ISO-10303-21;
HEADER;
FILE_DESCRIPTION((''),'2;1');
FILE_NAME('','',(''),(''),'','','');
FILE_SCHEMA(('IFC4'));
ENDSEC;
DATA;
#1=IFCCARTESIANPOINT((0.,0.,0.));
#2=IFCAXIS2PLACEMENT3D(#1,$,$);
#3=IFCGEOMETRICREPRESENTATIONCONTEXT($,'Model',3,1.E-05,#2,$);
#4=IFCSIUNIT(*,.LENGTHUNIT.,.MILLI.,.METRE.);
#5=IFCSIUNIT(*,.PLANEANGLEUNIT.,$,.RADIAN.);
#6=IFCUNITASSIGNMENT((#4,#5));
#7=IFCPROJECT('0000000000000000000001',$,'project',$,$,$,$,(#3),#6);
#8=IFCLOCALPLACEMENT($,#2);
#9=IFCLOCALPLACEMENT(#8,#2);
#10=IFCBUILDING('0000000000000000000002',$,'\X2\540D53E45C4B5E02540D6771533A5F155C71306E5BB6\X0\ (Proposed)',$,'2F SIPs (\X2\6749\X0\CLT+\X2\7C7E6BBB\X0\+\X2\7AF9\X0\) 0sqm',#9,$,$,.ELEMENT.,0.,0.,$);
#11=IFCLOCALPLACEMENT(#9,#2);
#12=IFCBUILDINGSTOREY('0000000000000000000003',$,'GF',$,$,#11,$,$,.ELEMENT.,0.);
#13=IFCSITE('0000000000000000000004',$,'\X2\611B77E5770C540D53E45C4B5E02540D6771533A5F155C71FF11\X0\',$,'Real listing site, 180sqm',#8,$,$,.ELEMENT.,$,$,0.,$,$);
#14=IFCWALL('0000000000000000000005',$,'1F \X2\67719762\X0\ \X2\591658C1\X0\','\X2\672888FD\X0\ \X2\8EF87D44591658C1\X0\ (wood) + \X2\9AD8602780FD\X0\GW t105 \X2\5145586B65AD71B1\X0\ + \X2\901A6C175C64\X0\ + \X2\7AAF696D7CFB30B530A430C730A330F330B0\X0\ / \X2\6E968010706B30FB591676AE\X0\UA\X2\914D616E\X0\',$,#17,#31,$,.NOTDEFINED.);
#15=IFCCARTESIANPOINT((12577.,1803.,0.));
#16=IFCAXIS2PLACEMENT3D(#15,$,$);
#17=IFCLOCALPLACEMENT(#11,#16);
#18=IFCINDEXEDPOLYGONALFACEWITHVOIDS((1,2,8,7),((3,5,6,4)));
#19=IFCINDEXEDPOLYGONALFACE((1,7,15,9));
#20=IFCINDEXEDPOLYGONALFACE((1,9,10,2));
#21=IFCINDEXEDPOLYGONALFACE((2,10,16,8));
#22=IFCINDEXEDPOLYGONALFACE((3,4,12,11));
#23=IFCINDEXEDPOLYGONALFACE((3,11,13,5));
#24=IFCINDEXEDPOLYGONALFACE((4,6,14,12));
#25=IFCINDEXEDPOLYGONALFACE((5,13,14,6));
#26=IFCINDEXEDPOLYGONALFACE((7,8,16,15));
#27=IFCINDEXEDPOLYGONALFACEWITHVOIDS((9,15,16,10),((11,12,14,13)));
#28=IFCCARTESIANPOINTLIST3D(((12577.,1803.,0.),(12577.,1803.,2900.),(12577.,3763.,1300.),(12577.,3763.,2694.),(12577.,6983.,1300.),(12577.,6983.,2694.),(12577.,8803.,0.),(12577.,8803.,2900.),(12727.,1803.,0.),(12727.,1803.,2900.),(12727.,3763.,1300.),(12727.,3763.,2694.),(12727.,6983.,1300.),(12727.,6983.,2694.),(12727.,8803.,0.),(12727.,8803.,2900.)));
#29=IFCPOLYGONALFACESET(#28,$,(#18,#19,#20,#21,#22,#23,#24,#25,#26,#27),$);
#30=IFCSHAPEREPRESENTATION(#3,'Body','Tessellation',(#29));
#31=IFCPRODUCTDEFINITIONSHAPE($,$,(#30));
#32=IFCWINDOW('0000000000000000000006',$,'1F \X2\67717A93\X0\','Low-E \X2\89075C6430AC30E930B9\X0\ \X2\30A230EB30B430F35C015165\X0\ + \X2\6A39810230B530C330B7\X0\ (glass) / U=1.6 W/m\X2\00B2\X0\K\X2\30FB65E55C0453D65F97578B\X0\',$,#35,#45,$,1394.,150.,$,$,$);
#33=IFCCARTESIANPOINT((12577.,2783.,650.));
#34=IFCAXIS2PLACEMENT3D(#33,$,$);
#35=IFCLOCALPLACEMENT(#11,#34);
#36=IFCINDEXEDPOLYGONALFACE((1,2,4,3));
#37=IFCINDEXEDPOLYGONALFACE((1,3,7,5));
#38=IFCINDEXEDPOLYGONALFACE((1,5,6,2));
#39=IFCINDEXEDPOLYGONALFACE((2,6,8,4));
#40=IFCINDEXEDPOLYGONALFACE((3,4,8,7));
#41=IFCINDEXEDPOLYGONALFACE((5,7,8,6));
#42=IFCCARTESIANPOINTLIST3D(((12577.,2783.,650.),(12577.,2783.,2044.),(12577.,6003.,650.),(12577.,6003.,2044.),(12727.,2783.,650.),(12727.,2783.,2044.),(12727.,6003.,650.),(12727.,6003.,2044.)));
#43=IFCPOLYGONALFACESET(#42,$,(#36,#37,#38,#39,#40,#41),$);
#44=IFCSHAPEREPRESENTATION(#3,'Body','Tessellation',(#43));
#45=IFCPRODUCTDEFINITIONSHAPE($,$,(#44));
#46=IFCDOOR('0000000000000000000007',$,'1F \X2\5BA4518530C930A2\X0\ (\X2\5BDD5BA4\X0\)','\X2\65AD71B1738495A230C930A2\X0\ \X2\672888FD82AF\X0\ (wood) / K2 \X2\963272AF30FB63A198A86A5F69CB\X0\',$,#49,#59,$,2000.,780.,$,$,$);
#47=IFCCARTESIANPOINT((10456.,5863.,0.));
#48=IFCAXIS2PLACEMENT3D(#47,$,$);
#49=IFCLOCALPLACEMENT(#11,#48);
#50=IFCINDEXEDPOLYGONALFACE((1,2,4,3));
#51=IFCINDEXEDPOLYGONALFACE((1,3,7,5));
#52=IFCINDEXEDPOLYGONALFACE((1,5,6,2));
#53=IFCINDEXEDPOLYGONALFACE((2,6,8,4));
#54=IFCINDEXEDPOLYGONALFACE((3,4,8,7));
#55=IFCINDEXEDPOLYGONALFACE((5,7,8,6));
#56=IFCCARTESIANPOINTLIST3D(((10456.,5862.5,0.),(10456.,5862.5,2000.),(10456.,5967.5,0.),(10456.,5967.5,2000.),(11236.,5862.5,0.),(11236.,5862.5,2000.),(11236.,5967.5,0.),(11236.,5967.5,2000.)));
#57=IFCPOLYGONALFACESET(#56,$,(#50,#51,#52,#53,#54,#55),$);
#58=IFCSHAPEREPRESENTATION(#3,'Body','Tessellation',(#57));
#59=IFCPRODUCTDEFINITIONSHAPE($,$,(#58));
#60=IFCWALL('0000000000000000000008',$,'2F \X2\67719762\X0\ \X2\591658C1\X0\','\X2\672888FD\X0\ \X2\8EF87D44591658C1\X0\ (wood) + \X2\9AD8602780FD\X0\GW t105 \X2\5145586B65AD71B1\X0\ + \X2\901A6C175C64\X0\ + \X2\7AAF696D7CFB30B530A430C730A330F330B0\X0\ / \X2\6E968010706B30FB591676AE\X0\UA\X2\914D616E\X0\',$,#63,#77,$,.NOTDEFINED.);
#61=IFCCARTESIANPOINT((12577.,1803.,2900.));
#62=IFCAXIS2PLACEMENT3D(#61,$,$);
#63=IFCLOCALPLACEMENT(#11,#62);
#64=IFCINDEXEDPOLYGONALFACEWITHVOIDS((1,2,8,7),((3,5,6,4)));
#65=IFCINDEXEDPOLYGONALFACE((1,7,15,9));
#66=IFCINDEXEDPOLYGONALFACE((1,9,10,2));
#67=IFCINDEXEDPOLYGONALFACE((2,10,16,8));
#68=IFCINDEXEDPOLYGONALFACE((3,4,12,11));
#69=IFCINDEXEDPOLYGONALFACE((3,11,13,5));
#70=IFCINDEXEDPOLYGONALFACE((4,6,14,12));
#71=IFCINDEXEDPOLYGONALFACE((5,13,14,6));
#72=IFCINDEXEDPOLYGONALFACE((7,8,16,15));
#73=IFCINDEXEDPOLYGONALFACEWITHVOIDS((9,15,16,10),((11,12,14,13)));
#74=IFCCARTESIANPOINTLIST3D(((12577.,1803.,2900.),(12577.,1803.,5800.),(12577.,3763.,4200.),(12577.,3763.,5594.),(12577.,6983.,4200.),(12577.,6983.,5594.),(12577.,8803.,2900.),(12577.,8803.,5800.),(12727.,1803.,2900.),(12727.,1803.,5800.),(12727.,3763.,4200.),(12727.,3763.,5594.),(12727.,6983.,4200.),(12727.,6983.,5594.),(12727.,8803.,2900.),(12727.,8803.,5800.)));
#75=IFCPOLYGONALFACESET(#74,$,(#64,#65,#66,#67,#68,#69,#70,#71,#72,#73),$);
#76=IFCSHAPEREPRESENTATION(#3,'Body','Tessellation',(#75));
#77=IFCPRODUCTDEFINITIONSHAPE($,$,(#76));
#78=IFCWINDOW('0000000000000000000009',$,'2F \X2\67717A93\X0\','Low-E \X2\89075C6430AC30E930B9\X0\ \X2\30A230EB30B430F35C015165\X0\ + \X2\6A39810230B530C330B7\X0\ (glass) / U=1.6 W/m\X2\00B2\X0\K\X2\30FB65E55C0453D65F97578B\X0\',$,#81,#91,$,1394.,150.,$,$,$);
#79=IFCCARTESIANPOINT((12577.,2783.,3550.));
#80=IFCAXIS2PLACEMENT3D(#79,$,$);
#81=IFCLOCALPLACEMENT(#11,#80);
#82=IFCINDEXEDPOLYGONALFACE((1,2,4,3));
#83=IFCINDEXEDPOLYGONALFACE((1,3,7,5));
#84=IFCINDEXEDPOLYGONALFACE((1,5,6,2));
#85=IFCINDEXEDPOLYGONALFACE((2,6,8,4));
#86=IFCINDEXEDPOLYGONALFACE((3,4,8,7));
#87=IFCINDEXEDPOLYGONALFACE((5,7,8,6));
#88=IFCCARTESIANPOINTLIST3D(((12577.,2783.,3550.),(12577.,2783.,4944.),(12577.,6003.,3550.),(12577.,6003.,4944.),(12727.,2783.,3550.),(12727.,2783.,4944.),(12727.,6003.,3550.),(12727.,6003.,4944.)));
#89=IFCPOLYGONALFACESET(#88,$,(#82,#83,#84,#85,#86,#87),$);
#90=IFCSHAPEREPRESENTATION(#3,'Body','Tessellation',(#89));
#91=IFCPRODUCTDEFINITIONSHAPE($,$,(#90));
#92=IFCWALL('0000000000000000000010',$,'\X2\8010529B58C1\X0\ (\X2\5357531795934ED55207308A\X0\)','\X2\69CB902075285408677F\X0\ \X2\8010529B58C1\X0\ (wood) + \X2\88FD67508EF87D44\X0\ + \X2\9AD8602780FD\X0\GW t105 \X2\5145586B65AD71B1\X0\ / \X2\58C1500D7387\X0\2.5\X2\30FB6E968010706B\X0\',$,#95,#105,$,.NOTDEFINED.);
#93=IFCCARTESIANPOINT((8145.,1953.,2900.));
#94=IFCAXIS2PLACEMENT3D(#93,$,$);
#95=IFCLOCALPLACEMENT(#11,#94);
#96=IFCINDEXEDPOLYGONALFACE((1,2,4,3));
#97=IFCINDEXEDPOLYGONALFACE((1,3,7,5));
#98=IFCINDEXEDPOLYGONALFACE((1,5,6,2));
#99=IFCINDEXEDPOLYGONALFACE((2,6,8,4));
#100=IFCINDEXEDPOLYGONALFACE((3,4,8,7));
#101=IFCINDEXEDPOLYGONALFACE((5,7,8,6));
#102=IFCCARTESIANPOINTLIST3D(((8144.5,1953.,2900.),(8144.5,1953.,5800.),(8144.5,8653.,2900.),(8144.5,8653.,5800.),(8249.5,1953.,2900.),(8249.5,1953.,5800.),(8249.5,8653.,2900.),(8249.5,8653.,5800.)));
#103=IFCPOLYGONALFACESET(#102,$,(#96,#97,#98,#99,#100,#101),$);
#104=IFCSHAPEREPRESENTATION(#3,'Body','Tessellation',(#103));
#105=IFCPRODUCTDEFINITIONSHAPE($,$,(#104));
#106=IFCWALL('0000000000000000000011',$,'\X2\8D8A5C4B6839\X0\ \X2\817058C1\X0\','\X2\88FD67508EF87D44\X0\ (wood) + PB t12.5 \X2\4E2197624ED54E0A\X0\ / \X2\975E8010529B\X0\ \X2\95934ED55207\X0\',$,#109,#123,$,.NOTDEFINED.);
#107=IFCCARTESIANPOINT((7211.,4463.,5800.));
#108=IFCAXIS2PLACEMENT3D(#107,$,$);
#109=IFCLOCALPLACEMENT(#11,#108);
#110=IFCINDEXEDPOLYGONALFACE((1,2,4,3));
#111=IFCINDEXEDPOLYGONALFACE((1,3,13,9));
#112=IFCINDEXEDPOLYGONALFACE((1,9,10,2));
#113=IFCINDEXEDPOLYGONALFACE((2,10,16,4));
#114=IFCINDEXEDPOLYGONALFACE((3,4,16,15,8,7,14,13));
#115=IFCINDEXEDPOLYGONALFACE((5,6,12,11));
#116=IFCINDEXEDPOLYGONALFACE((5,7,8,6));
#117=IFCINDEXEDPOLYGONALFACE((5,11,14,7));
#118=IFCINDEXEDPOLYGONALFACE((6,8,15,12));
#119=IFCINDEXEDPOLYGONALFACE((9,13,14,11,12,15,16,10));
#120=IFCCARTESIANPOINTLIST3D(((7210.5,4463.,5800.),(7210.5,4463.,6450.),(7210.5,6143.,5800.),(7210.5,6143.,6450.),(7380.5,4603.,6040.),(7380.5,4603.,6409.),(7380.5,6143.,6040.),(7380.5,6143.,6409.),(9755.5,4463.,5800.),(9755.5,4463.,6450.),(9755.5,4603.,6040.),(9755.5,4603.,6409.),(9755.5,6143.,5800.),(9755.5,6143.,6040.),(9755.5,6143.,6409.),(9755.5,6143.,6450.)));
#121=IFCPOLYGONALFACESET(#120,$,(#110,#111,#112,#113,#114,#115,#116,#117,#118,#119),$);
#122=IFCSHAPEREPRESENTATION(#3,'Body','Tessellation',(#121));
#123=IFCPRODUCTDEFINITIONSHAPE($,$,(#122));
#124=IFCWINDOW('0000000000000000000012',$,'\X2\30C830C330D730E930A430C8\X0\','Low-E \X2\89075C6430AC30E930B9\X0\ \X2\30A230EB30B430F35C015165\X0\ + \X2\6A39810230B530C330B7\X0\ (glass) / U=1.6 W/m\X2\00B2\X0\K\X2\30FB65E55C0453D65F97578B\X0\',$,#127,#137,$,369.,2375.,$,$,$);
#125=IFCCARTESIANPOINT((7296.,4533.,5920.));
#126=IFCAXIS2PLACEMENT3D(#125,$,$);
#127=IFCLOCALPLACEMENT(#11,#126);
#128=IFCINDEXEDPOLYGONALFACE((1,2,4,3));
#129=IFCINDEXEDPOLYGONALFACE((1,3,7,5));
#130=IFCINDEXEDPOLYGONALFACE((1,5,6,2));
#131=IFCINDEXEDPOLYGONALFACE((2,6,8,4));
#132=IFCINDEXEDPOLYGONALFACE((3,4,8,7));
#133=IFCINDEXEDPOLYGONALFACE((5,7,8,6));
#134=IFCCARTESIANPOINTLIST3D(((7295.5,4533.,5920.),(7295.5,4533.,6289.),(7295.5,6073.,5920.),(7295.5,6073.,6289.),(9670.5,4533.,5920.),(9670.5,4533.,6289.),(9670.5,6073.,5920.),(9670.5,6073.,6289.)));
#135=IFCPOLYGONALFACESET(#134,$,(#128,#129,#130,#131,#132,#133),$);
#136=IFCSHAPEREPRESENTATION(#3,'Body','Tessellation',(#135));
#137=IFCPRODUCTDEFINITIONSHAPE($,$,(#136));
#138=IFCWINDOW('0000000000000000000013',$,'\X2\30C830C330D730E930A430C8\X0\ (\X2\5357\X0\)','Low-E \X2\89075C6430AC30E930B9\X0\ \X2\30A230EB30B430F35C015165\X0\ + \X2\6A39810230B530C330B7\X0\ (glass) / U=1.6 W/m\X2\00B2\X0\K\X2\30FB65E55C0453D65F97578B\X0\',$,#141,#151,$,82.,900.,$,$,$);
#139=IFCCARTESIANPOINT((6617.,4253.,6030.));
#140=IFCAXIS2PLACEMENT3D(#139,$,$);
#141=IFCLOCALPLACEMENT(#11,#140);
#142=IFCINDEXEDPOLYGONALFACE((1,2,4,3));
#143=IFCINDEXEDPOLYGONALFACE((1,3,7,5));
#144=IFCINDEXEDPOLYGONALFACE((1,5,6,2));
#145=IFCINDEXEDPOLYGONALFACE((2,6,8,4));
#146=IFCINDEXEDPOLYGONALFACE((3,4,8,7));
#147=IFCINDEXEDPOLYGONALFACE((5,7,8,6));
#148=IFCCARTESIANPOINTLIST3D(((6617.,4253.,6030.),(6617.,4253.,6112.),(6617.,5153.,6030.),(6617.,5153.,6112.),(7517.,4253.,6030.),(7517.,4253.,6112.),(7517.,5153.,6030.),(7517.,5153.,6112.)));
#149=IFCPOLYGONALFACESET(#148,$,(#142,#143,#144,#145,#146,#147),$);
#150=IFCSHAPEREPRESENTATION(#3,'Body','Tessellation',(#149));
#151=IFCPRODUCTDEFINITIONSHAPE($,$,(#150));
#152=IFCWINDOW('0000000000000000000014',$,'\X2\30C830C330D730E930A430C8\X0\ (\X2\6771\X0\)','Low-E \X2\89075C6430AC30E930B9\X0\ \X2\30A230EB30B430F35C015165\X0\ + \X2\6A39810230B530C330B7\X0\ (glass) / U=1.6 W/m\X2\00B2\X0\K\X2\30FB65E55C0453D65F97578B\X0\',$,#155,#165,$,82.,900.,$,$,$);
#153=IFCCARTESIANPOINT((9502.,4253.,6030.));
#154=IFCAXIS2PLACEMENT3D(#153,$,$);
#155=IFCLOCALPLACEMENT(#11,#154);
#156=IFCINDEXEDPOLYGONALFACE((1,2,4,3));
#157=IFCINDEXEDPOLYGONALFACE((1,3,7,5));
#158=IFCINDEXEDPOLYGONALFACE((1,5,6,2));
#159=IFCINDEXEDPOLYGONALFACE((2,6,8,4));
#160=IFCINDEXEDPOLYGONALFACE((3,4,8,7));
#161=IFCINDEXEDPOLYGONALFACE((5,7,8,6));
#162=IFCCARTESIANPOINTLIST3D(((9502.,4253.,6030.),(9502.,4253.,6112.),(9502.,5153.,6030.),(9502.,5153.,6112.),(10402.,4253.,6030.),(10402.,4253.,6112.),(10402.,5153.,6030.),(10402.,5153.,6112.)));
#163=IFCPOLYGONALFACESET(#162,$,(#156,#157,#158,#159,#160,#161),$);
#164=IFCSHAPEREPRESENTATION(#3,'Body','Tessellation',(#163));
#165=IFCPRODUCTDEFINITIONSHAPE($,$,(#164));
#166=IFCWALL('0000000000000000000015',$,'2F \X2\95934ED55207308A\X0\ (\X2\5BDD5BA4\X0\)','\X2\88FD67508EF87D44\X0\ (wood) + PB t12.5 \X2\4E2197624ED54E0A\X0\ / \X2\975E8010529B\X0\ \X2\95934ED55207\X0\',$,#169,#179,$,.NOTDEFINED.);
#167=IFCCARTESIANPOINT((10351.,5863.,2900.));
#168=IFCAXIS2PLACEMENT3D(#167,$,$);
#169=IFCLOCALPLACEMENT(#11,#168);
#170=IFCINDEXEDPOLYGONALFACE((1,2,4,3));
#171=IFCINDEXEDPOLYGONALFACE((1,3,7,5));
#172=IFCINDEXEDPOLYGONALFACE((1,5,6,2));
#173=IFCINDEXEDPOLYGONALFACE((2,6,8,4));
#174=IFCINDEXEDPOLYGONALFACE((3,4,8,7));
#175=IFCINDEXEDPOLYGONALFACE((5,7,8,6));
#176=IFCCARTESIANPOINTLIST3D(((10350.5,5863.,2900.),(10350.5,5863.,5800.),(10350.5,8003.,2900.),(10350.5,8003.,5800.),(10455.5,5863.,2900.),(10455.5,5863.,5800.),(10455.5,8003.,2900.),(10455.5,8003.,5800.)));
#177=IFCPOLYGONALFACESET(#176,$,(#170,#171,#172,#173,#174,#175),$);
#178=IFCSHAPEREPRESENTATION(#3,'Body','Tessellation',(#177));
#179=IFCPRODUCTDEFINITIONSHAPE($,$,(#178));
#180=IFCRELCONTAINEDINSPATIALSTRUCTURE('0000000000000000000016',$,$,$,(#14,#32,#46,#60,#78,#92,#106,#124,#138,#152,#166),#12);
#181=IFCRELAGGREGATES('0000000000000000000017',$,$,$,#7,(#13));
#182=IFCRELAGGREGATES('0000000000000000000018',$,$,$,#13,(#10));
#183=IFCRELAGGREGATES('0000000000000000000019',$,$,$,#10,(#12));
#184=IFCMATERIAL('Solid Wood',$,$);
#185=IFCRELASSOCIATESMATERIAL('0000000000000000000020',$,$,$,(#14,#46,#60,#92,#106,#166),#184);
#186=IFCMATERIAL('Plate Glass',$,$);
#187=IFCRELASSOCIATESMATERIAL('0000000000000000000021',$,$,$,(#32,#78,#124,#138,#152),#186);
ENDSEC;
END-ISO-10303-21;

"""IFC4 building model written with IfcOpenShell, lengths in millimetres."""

from ifc_helpers import new_model, si_unit, frame, frame_2d, origin, place, context, project, spatial, rectangle, extrude, material, element, fill, save


model = new_model("IFC4")

# Units and contexts
model_context = context("Model", 3, precision=1e-05, world=origin())
ifc_project = project(units=[si_unit("LENGTHUNIT", "METRE", prefix="MILLI"), si_unit("PLANEANGLEUNIT", "RADIAN")], contexts=[model_context])

# Site, building, storey
site_placement = place(None, origin())
site = spatial("IfcSite", under=ifc_project, at=site_placement, Name="愛知県名古屋市名東区引山１", ObjectType="Real listing site, 180sqm", CompositionType="ELEMENT", RefElevation=0.0)
building_placement = place(site_placement, origin())
building = spatial("IfcBuilding", under=site, at=building_placement, Name="名古屋市名東区引山の家 (Proposed)", ObjectType="2F SIPs (杉CLT+籾殻+竹) 0sqm", CompositionType="ELEMENT", ElevationOfRefHeight=0.0, ElevationOfTerrain=0.0)
storey_placement = place(building_placement, origin())
storey = spatial("IfcBuildingStorey", under=building, at=storey_placement, Name="GF", CompositionType="ELEMENT", Elevation=0.0)

# Wall, opening, window
ifc_material_1 = material(Name="Solid Wood")
wall_1_placement = place(storey_placement, frame((12577.0, 1803.0, 0.0)))
wall_1 = element("IfcWall", 1, at=wall_1_placement, inside=storey, material=ifc_material_1, Name="1F 東面 外壁", Description="木製 軸組外壁 (wood) + 高性能GW t105 充填断熱 + 通気層 + 窯業系サイディング / 準耐火・外皮UA配慮", PredefinedType="NOTDEFINED", context=model_context, shape_type="SweptSolid", body=[
    extrude(rectangle(XDim=150.0, YDim=7000.0, at=frame_2d((75.0, 3500.0))), frame((12577.0, 1803.0, 0.0)), (0.0, 0.0, 1.0), 2900.0),
])
opening_1_placement = place(storey_placement, frame((12577.0, 2783.0, 650.0)))
opening_1 = element("IfcOpeningElement", 2, at=opening_1_placement, cuts=wall_1, PredefinedType="NOTDEFINED", context=model_context, shape_type="SweptSolid", body=[
    extrude(rectangle(XDim=150.0, YDim=3220.0, at=frame_2d((75.0, 1610.0))), frame((12577.0, 2783.0, 650.0)), (0.0, 0.0, 1.0), 1394.0),
])
ifc_material_2 = material(Name="Plate Glass")
window_1_placement = place(storey_placement, frame((12577.0, 2783.0, 650.0)))
window_1 = element("IfcWindow", 3, at=window_1_placement, inside=storey, material=ifc_material_2, Name="1F 東窓", Description="Low-E 複層ガラス アルゴン封入 + 樹脂サッシ (glass) / U=1.6 W/m²K・日射取得型", OverallHeight=1394.0, OverallWidth=150.0, context=model_context, shape_type="SweptSolid", body=[
    extrude(rectangle(XDim=150.0, YDim=3220.0, at=frame_2d((75.0, 1610.0))), frame((12577.0, 2783.0, 650.0)), (0.0, 0.0, 1.0), 1394.0),
])
fill(opening_1, window_1)

# Door
door_1_placement = place(storey_placement, frame((10456.0, 5863.0, 0.0)))
element("IfcDoor", 4, at=door_1_placement, inside=storey, material=ifc_material_1, Name="1F 室内ドア (寝室)", Description="断熱玄関ドア 木製芯 (wood) / K2 防犯・採風機構", OverallHeight=2000.0, OverallWidth=780.0, context=model_context, shape_type="SweptSolid", body=[
    extrude(rectangle(XDim=780.0, YDim=105.0, at=frame_2d((390.0, 52.0))), frame((10456.0, 5863.0, 0.0)), (0.0, 0.0, 1.0), 2000.0),
])

# Wall, opening, window
wall_2_placement = place(storey_placement, frame((12577.0, 1803.0, 2900.0)))
wall_2 = element("IfcWall", 5, at=wall_2_placement, inside=storey, material=ifc_material_1, Name="2F 東面 外壁", Description="木製 軸組外壁 (wood) + 高性能GW t105 充填断熱 + 通気層 + 窯業系サイディング / 準耐火・外皮UA配慮", PredefinedType="NOTDEFINED", context=model_context, shape_type="SweptSolid", body=[
    extrude(rectangle(XDim=150.0, YDim=7000.0, at=frame_2d((75.0, 3500.0))), frame((12577.0, 1803.0, 2900.0)), (0.0, 0.0, 1.0), 2900.0),
])
opening_2_placement = place(storey_placement, frame((12577.0, 2783.0, 3550.0)))
opening_2 = element("IfcOpeningElement", 6, at=opening_2_placement, cuts=wall_2, PredefinedType="NOTDEFINED", context=model_context, shape_type="SweptSolid", body=[
    extrude(rectangle(XDim=150.0, YDim=3220.0, at=frame_2d((75.0, 1610.0))), frame((12577.0, 2783.0, 3550.0)), (0.0, 0.0, 1.0), 1394.0),
])
window_2_placement = place(storey_placement, frame((12577.0, 2783.0, 3550.0)))
window_2 = element("IfcWindow", 7, at=window_2_placement, inside=storey, material=ifc_material_2, Name="2F 東窓", Description="Low-E 複層ガラス アルゴン封入 + 樹脂サッシ (glass) / U=1.6 W/m²K・日射取得型", OverallHeight=1394.0, OverallWidth=150.0, context=model_context, shape_type="SweptSolid", body=[
    extrude(rectangle(XDim=150.0, YDim=3220.0, at=frame_2d((75.0, 1610.0))), frame((12577.0, 2783.0, 3550.0)), (0.0, 0.0, 1.0), 1394.0),
])
fill(opening_2, window_2)

# Wall
wall_3_placement = place(storey_placement, frame((8145.0, 1953.0, 2900.0)))
element("IfcWall", 8, at=wall_3_placement, inside=storey, material=ifc_material_1, Name="耐力壁 (南北間仕切り)", Description="構造用合板 耐力壁 (wood) + 製材軸組 + 高性能GW t105 充填断熱 / 壁倍率2.5・準耐火", PredefinedType="NOTDEFINED", context=model_context, shape_type="SweptSolid", body=[
    extrude(rectangle(XDim=105.0, YDim=6700.0, at=frame_2d((52.0, 3350.0))), frame((8145.0, 1953.0, 2900.0)), (0.0, 0.0, 1.0), 2900.0),
])

# Wall, openings, windows
wall_4_placement = place(storey_placement, frame((7211.0, 4463.0, 5800.0)))
wall_4 = element("IfcWall", 9, at=wall_4_placement, inside=storey, material=ifc_material_1, Name="越屋根 腰壁", Description="製材軸組 (wood) + PB t12.5 両面仕上 / 非耐力 間仕切", PredefinedType="NOTDEFINED", context=model_context, shape_type="SweptSolid", body=[
    extrude(rectangle(XDim=2545.0, YDim=1680.0, at=frame_2d((1272.0, 840.0))), frame((7211.0, 4463.0, 5800.0)), (0.0, 0.0, 1.0), 650.0),
])
opening_3_placement = place(storey_placement, frame((7296.0, 4533.0, 5920.0)))
opening_3 = element("IfcOpeningElement", 10, at=opening_3_placement, cuts=wall_4, PredefinedType="NOTDEFINED", context=model_context, shape_type="SweptSolid", body=[
    extrude(rectangle(XDim=2375.0, YDim=1540.0, at=frame_2d((1187.0, 770.0))), frame((7296.0, 4533.0, 5920.0)), (0.0, 0.0, 1.0), 369.0),
])
opening_4_placement = place(storey_placement, frame((6617.0, 4253.0, 6030.0)))
opening_4 = element("IfcOpeningElement", 11, at=opening_4_placement, cuts=wall_4, PredefinedType="NOTDEFINED", context=model_context, shape_type="SweptSolid", body=[
    extrude(rectangle(XDim=900.0, YDim=900.0, at=frame_2d((450.0, 450.0))), frame((6617.0, 4253.0, 6030.0)), (0.0, 0.0, 1.0), 82.0),
])
opening_5_placement = place(storey_placement, frame((9502.0, 4253.0, 6030.0)))
opening_5 = element("IfcOpeningElement", 12, at=opening_5_placement, cuts=wall_4, PredefinedType="NOTDEFINED", context=model_context, shape_type="SweptSolid", body=[
    extrude(rectangle(XDim=900.0, YDim=900.0, at=frame_2d((450.0, 450.0))), frame((9502.0, 4253.0, 6030.0)), (0.0, 0.0, 1.0), 82.0),
])
window_3_placement = place(storey_placement, frame((7296.0, 4533.0, 5920.0)))
window_3 = element("IfcWindow", 13, at=window_3_placement, inside=storey, material=ifc_material_2, Name="トップライト", Description="Low-E 複層ガラス アルゴン封入 + 樹脂サッシ (glass) / U=1.6 W/m²K・日射取得型", OverallHeight=369.0, OverallWidth=2375.0, context=model_context, shape_type="SweptSolid", body=[
    extrude(rectangle(XDim=2375.0, YDim=1540.0, at=frame_2d((1187.0, 770.0))), frame((7296.0, 4533.0, 5920.0)), (0.0, 0.0, 1.0), 369.0),
])
fill(opening_3, window_3)
window_4_placement = place(storey_placement, frame((6617.0, 4253.0, 6030.0)))
window_4 = element("IfcWindow", 14, at=window_4_placement, inside=storey, material=ifc_material_2, Name="トップライト (南)", Description="Low-E 複層ガラス アルゴン封入 + 樹脂サッシ (glass) / U=1.6 W/m²K・日射取得型", OverallHeight=82.0, OverallWidth=900.0, context=model_context, shape_type="SweptSolid", body=[
    extrude(rectangle(XDim=900.0, YDim=900.0, at=frame_2d((450.0, 450.0))), frame((6617.0, 4253.0, 6030.0)), (0.0, 0.0, 1.0), 82.0),
])
fill(opening_4, window_4)
window_5_placement = place(storey_placement, frame((9502.0, 4253.0, 6030.0)))
window_5 = element("IfcWindow", 15, at=window_5_placement, inside=storey, material=ifc_material_2, Name="トップライト (東)", Description="Low-E 複層ガラス アルゴン封入 + 樹脂サッシ (glass) / U=1.6 W/m²K・日射取得型", OverallHeight=82.0, OverallWidth=900.0, context=model_context, shape_type="SweptSolid", body=[
    extrude(rectangle(XDim=900.0, YDim=900.0, at=frame_2d((450.0, 450.0))), frame((9502.0, 4253.0, 6030.0)), (0.0, 0.0, 1.0), 82.0),
])
fill(opening_5, window_5)

# Wall
wall_5_placement = place(storey_placement, frame((10351.0, 5863.0, 2900.0)))
element("IfcWall", 16, at=wall_5_placement, inside=storey, material=ifc_material_1, Name="2F 間仕切り (寝室)", Description="製材軸組 (wood) + PB t12.5 両面仕上 / 非耐力 間仕切", PredefinedType="NOTDEFINED", context=model_context, shape_type="SweptSolid", body=[
    extrude(rectangle(XDim=105.0, YDim=2140.0, at=frame_2d((52.0, 1070.0))), frame((10351.0, 5863.0, 2900.0)), (0.0, 0.0, 1.0), 2900.0),
])

save(model, "model.ifc")
